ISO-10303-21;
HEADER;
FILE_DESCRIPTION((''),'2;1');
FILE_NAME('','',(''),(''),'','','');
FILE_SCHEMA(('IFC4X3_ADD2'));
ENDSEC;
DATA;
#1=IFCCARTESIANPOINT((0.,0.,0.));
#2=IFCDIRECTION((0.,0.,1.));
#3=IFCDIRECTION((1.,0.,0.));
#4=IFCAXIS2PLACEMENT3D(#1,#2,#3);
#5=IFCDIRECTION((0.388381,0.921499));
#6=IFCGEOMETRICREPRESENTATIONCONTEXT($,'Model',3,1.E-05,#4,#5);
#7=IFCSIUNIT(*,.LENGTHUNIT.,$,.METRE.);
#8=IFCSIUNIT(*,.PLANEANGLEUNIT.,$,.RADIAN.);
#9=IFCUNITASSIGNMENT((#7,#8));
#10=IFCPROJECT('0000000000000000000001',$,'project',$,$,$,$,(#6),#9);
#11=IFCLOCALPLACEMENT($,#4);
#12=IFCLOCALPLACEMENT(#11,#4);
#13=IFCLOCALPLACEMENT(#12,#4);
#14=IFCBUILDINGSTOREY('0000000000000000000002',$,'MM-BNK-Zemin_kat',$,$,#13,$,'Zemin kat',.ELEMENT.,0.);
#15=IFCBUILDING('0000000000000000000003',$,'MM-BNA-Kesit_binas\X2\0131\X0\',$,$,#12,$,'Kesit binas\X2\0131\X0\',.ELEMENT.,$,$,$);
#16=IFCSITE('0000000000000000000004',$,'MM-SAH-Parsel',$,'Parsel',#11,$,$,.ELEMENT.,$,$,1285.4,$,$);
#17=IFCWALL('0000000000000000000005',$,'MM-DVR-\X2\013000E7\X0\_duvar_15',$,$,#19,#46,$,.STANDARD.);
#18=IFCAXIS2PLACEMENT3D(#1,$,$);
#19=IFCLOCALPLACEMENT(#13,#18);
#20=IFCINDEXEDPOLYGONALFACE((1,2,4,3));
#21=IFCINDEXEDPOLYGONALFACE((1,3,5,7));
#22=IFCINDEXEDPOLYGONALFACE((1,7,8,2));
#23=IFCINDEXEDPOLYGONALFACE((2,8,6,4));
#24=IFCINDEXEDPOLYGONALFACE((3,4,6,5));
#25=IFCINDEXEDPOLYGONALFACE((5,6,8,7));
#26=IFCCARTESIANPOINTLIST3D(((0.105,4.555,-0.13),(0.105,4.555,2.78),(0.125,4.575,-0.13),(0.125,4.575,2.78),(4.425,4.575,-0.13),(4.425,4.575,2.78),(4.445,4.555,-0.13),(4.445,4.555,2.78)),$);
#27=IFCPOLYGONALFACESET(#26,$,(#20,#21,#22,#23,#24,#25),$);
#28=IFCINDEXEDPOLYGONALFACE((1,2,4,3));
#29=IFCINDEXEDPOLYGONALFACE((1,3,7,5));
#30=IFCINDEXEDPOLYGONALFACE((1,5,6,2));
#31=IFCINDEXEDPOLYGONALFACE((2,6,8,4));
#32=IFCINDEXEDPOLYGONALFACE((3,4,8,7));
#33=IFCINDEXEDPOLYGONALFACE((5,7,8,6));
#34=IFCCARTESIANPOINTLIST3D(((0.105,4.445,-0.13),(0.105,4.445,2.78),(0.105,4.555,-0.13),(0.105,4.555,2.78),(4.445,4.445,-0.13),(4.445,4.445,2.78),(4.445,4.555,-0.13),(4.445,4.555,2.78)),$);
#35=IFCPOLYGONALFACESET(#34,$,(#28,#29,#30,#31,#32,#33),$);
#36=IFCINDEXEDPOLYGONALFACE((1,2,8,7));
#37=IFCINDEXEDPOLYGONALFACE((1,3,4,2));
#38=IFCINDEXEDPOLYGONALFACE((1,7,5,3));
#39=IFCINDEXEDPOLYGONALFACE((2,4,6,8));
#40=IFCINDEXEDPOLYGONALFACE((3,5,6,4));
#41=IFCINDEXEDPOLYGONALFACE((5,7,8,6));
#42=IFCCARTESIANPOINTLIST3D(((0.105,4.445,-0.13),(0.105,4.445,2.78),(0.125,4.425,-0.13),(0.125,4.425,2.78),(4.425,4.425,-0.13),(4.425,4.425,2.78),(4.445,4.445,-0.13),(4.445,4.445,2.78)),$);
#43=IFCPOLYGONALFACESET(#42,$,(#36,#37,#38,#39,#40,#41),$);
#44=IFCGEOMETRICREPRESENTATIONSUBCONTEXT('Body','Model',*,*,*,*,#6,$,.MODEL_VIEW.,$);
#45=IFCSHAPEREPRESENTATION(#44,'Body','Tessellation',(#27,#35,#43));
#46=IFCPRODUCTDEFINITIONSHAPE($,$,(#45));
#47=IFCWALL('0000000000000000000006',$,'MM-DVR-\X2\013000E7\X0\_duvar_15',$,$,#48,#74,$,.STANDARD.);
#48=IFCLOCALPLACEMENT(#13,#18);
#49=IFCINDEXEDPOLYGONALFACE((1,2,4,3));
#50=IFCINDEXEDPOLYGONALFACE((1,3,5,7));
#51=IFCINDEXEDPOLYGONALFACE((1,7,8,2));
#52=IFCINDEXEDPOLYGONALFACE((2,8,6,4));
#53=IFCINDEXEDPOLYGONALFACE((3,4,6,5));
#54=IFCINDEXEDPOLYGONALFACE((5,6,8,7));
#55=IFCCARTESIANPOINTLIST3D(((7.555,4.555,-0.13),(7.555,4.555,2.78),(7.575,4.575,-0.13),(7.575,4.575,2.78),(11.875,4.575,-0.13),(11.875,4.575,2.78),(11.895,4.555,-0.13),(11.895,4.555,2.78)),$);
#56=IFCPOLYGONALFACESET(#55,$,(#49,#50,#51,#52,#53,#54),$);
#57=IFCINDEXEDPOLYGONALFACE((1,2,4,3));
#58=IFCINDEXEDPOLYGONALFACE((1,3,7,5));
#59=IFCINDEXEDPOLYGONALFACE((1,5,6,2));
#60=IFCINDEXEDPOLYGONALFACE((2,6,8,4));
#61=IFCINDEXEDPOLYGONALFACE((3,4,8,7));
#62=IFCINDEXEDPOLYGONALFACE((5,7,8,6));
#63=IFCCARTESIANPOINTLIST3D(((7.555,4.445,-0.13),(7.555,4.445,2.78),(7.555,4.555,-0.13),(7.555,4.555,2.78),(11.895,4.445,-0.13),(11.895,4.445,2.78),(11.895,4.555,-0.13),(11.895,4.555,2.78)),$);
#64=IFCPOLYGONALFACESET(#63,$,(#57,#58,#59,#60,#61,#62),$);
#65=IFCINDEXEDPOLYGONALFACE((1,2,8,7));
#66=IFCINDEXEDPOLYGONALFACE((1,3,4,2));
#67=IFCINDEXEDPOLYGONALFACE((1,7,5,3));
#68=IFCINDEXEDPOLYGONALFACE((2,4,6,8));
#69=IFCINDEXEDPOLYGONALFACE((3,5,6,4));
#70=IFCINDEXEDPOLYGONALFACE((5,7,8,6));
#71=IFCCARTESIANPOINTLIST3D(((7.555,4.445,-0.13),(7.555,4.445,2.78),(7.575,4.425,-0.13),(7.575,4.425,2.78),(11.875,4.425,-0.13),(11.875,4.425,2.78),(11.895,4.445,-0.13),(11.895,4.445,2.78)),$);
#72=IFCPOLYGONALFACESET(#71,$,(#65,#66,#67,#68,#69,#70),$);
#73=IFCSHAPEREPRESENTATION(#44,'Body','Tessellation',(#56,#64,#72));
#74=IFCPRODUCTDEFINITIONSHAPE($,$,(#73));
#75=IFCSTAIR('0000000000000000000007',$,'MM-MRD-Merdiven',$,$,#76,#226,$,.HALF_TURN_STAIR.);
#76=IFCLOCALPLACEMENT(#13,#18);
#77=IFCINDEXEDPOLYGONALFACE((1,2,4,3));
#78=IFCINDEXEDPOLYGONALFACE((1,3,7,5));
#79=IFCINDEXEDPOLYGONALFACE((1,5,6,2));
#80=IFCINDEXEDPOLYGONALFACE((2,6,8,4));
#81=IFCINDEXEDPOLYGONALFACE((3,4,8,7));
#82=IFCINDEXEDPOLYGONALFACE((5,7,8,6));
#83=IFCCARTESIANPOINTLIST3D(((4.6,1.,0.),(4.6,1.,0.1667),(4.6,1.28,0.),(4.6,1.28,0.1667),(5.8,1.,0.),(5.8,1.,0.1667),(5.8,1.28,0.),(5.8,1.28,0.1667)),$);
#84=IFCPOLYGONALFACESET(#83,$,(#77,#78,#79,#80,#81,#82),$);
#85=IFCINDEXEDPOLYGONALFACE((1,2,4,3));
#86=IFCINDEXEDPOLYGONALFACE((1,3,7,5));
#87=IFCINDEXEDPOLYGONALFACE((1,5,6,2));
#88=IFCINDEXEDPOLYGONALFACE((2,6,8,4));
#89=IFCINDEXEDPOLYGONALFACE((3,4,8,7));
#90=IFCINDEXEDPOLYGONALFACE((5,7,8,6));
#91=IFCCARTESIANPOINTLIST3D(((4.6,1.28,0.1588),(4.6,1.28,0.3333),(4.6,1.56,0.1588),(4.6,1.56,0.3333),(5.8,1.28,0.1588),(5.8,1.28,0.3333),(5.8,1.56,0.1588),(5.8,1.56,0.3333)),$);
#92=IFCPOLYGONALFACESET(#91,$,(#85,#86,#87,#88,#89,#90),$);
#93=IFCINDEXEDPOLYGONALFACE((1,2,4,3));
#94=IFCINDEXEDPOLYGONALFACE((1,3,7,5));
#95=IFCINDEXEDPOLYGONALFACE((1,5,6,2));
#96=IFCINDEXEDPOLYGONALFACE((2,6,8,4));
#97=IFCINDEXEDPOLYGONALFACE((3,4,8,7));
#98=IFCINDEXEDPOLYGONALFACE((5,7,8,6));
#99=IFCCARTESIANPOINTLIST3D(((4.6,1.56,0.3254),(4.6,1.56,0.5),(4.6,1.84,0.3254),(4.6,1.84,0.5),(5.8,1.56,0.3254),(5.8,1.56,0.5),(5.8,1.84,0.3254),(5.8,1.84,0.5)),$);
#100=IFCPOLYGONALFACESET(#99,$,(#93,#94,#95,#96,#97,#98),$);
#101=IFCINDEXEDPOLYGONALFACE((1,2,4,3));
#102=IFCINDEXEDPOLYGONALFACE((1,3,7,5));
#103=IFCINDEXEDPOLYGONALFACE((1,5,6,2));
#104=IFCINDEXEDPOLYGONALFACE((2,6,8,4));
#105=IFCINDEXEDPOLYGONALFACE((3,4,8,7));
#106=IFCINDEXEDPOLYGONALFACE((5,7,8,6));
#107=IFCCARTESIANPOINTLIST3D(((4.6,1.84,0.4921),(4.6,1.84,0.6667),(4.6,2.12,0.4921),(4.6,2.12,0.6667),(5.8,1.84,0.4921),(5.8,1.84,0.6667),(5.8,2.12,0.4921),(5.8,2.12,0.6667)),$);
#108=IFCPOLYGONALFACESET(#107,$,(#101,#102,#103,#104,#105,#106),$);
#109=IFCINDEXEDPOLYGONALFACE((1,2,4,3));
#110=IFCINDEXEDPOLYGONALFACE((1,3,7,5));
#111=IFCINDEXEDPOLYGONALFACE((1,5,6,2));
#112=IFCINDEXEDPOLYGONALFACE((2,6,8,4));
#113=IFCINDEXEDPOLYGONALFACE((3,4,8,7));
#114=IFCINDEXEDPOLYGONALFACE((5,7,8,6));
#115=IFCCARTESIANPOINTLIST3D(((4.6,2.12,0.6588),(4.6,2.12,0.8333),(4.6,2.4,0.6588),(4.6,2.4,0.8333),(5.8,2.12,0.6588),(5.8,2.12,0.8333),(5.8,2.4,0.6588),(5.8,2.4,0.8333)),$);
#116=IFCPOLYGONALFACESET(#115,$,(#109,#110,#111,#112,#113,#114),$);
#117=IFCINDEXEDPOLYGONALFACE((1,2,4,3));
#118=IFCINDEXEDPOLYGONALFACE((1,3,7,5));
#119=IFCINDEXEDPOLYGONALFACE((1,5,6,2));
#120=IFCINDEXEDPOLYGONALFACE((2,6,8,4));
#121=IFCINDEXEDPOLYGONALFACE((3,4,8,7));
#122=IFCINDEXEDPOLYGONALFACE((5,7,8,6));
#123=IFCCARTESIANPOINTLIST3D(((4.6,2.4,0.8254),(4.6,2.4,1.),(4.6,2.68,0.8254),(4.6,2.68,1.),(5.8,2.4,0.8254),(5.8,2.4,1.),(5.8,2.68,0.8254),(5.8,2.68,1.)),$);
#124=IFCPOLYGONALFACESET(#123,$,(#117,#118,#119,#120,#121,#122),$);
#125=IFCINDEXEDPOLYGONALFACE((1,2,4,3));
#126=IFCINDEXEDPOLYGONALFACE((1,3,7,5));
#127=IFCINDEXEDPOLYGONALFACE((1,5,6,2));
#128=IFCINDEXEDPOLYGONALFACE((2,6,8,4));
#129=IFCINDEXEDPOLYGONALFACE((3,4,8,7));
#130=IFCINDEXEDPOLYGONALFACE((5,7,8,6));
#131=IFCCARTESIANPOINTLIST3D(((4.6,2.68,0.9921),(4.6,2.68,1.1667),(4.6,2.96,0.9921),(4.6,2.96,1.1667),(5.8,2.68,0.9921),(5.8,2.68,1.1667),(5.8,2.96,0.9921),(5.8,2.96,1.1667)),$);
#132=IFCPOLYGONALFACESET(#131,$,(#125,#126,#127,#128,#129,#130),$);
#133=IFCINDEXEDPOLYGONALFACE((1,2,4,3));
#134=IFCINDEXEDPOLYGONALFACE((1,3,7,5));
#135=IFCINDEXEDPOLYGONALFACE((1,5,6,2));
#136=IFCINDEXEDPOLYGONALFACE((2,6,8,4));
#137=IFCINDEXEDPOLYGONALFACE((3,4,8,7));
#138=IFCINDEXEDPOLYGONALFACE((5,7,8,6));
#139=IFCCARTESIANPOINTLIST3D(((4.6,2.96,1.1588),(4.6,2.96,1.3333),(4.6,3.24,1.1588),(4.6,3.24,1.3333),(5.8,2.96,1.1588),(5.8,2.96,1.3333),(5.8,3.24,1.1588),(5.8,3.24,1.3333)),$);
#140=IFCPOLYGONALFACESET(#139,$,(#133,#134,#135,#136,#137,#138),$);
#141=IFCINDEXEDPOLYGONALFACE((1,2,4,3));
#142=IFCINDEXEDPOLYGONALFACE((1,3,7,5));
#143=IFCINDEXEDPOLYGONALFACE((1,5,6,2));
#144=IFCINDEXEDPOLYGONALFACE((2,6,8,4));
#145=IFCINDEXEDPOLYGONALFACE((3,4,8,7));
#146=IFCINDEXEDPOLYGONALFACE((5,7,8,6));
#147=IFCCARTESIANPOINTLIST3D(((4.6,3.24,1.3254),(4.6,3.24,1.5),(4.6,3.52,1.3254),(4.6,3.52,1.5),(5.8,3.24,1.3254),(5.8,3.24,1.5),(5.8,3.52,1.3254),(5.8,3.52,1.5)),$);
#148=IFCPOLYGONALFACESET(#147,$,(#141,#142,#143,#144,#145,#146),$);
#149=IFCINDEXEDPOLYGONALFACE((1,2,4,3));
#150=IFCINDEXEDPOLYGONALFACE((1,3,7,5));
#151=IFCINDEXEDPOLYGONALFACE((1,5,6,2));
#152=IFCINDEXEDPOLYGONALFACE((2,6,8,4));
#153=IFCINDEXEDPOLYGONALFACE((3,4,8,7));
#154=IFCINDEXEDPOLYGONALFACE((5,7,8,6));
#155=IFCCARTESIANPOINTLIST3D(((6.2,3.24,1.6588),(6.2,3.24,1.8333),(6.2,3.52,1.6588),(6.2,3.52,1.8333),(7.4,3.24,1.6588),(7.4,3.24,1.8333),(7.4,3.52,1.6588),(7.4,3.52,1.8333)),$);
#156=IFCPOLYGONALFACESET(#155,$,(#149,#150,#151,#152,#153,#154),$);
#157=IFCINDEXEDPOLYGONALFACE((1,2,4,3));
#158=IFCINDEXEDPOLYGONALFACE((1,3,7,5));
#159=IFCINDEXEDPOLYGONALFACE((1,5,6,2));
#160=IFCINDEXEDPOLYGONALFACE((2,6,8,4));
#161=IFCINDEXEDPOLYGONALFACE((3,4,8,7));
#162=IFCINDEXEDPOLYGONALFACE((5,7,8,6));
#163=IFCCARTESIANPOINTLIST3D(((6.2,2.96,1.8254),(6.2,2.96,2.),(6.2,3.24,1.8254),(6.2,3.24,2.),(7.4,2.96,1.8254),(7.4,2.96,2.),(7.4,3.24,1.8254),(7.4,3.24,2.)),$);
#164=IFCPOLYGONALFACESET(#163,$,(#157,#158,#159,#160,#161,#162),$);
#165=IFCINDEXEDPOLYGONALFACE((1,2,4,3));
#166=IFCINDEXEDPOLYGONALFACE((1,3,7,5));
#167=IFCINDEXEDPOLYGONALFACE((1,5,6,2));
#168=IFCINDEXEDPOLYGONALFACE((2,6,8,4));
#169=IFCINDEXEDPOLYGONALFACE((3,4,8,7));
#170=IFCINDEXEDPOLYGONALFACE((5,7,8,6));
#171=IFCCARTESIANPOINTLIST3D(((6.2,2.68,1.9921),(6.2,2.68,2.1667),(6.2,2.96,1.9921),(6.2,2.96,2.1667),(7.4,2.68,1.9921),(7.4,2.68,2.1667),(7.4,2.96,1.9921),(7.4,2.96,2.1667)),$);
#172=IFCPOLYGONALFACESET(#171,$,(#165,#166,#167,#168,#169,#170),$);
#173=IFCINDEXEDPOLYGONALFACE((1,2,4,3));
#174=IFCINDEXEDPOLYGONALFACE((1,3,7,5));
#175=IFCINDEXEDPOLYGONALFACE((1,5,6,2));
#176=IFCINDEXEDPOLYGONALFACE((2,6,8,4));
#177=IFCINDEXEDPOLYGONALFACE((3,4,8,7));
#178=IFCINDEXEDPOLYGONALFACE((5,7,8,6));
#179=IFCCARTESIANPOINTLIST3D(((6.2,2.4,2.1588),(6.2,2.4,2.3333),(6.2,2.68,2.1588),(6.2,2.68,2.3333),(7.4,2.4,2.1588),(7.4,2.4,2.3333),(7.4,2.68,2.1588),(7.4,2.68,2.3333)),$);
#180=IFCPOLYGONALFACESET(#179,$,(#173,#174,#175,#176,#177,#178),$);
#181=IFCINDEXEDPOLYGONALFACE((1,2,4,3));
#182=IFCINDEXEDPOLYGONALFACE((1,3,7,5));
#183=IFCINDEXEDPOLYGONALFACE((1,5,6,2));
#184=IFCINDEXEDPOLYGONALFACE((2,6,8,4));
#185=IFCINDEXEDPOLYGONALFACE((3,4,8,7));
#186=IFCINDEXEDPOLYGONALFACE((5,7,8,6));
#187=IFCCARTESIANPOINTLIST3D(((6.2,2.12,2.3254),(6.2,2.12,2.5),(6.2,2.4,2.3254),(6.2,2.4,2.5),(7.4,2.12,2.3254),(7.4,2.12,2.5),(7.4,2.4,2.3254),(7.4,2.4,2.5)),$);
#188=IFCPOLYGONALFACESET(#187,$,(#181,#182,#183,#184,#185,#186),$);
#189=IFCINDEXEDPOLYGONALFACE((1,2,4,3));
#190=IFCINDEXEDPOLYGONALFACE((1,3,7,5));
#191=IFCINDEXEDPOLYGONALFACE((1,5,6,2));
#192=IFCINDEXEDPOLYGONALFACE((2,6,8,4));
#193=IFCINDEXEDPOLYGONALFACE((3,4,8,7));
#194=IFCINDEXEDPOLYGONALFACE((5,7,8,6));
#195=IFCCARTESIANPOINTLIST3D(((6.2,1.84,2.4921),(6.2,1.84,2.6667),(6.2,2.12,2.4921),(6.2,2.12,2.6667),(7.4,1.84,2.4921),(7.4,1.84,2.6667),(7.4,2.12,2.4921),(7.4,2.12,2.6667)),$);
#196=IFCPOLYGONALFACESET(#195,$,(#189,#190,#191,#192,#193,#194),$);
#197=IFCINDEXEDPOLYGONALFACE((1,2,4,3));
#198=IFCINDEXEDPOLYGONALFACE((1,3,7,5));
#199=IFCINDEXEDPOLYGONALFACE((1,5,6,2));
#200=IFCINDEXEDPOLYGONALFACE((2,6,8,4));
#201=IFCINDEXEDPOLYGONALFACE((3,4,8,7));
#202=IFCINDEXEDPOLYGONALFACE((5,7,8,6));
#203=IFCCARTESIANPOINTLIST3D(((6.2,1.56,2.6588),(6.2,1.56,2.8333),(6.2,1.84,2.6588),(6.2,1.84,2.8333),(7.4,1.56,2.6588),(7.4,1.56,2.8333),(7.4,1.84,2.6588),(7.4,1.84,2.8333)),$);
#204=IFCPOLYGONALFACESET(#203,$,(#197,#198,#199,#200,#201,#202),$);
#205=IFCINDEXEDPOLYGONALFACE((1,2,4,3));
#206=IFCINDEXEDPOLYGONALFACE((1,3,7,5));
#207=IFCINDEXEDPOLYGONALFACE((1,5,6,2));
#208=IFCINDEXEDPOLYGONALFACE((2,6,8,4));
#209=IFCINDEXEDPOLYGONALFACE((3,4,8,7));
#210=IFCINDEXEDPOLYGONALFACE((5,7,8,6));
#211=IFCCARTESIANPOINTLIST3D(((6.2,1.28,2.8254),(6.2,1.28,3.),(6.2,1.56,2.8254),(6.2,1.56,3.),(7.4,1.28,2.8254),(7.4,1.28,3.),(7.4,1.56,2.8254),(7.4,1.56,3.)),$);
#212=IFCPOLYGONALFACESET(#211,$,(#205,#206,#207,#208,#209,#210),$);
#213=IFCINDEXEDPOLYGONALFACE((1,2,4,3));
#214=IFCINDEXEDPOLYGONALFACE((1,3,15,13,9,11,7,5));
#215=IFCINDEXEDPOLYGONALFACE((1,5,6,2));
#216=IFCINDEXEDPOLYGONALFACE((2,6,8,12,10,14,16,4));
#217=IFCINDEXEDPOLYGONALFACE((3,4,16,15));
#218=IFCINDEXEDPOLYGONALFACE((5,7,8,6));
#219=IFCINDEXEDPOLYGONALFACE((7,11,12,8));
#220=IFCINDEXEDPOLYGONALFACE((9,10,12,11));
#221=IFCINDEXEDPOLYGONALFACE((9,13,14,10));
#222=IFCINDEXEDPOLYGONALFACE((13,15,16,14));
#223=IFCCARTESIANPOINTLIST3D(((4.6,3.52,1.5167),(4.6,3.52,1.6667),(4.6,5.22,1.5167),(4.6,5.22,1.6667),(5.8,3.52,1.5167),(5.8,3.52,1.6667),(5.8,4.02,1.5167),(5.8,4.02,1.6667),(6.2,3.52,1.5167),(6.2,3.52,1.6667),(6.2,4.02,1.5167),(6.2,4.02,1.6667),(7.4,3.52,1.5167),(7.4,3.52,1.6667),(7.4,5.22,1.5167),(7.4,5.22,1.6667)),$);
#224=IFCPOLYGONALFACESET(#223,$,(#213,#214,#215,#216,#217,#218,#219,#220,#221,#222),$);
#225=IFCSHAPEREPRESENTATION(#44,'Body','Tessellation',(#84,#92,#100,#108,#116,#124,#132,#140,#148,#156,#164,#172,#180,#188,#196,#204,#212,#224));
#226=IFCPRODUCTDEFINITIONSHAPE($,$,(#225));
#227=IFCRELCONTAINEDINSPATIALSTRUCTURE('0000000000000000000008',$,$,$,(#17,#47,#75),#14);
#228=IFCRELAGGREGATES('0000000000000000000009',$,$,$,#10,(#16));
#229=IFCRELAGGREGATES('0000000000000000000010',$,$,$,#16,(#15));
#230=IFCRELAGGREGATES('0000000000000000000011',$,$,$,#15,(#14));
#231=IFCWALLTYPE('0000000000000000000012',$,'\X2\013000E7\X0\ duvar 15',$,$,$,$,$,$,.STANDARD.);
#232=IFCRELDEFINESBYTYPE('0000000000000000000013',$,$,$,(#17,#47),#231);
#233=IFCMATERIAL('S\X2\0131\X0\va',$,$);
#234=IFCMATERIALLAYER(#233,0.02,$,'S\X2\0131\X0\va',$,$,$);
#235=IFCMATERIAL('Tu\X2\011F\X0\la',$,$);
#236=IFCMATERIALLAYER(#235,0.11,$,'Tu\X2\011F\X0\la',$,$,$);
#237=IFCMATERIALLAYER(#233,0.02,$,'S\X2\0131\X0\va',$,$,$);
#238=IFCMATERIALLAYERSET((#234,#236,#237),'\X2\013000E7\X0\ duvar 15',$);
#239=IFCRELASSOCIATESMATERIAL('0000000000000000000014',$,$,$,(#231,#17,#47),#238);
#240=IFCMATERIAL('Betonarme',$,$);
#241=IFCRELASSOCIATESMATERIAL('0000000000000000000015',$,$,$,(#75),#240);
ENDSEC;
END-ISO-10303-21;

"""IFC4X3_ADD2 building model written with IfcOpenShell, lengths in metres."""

from ifc_helpers import new_model, si_unit, direction, frame, origin, origin_with_axes, place, context, subcontext, project, spatial, polyline, outline, extrude, material, layer, layer_set, type_object, element, save


model = new_model("IFC4X3_ADD2")

# Units and contexts
model_context = context("Model", 3, precision=1e-05, world=origin_with_axes(), true_north=direction((0.388381, 0.921499)))
body_context = subcontext(model_context, "Body", "Model", "MODEL_VIEW")
ifc_project = project(units=[si_unit("LENGTHUNIT", "METRE"), si_unit("PLANEANGLEUNIT", "RADIAN")], contexts=[model_context])

# Site, building, storey
site_placement = place(None, origin_with_axes())
site = spatial("IfcSite", under=ifc_project, at=site_placement, Name="MM-SAH-Parsel", ObjectType="Parsel", CompositionType="ELEMENT", RefElevation=1285.4)
building_placement = place(site_placement, origin_with_axes())
building = spatial("IfcBuilding", under=site, at=building_placement, Name="MM-BNA-Kesit_binası", LongName="Kesit binası", CompositionType="ELEMENT")
storey_placement = place(building_placement, origin_with_axes())
storey = spatial("IfcBuildingStorey", under=building, at=storey_placement, Name="MM-BNK-Zemin_kat", LongName="Zemin kat", CompositionType="ELEMENT", Elevation=0.0)

# Shared definitions
ifc_material_1 = material(Name="Betonarme")

# Shared definitions
ifc_material_2 = material(Name="Tuğla")

# Shared definitions
ifc_material_3 = material(Name="Sıva")
ifc_layer_1 = layer(ifc_material_3, 0.02, Name="Sıva")
ifc_layer_2 = layer(ifc_material_2, 0.11, Name="Tuğla")
ifc_layer_3 = layer(ifc_material_3, 0.02, Name="Sıva")
ifc_layer_set_1 = layer_set([ifc_layer_1, ifc_layer_2, ifc_layer_3], Name="İç duvar 15")
wall_type_1 = type_object("IfcWallType", Name="İç duvar 15", PredefinedType="STANDARD", material=ifc_layer_set_1)

# Walls
wall_1_placement = place(storey_placement, origin_with_axes())
element("IfcWall", 1, at=wall_1_placement, inside=storey, type_object=wall_type_1, material=ifc_layer_set_1, Name="MM-DVR-İç_duvar_15", PredefinedType="STANDARD", context=body_context, shape_type="SweptSolid", body=[
    extrude(outline(polyline([(0.125, 4.575), (4.425, 4.575), (4.445, 4.555), (0.105, 4.555), (0.125, 4.575)])), frame((0.0, 0.0, -0.13)), (0.0, 0.0, 1.0), 2.91),
    extrude(outline(polyline([(0.105, 4.555), (4.445, 4.555), (4.445, 4.445), (0.105, 4.445), (0.105, 4.555)])), frame((0.0, 0.0, -0.13)), (0.0, 0.0, 1.0), 2.91),
    extrude(outline(polyline([(0.105, 4.445), (4.445, 4.445), (4.425, 4.425), (0.125, 4.425), (0.105, 4.445)])), frame((0.0, 0.0, -0.13)), (0.0, 0.0, 1.0), 2.91),
])
wall_2_placement = place(storey_placement, origin_with_axes())
element("IfcWall", 2, at=wall_2_placement, inside=storey, type_object=wall_type_1, material=ifc_layer_set_1, Name="MM-DVR-İç_duvar_15", PredefinedType="STANDARD", context=body_context, shape_type="SweptSolid", body=[
    extrude(outline(polyline([(7.575, 4.575), (11.875, 4.575), (11.895, 4.555), (7.555, 4.555), (7.575, 4.575)])), frame((0.0, 0.0, -0.13)), (0.0, 0.0, 1.0), 2.91),
    extrude(outline(polyline([(7.555, 4.555), (11.895, 4.555), (11.895, 4.445), (7.555, 4.445), (7.555, 4.555)])), frame((0.0, 0.0, -0.13)), (0.0, 0.0, 1.0), 2.91),
    extrude(outline(polyline([(7.555, 4.445), (11.895, 4.445), (11.875, 4.425), (7.575, 4.425), (7.555, 4.445)])), frame((0.0, 0.0, -0.13)), (0.0, 0.0, 1.0), 2.91),
])

# Stair
stair_placement = place(storey_placement, origin_with_axes())
element("IfcStair", 3, at=stair_placement, inside=storey, material=ifc_material_1, Name="MM-MRD-Merdiven", PredefinedType="HALF_TURN_STAIR", context=body_context, shape_type="SweptSolid", body=[
    extrude(outline(polyline([(5.8, 1.0), (5.8, 1.28), (4.6, 1.28), (4.6, 1.0), (5.8, 1.0)])), origin(), (0.0, 0.0, 1.0), 0.1667),
    extrude(outline(polyline([(5.8, 1.28), (5.8, 1.56), (4.6, 1.56), (4.6, 1.28), (5.8, 1.28)])), frame((0.0, 0.0, 0.1588)), (0.0, 0.0, 1.0), 0.1746),
    extrude(outline(polyline([(5.8, 1.56), (5.8, 1.84), (4.6, 1.84), (4.6, 1.56), (5.8, 1.56)])), frame((0.0, 0.0, 0.3254)), (0.0, 0.0, 1.0), 0.1746),
    extrude(outline(polyline([(5.8, 1.84), (5.8, 2.12), (4.6, 2.12), (4.6, 1.84), (5.8, 1.84)])), frame((0.0, 0.0, 0.4921)), (0.0, 0.0, 1.0), 0.1746),
    extrude(outline(polyline([(5.8, 2.12), (5.8, 2.4), (4.6, 2.4), (4.6, 2.12), (5.8, 2.12)])), frame((0.0, 0.0, 0.6588)), (0.0, 0.0, 1.0), 0.1746),
    extrude(outline(polyline([(5.8, 2.4), (5.8, 2.68), (4.6, 2.68), (4.6, 2.4), (5.8, 2.4)])), frame((0.0, 0.0, 0.8254)), (0.0, 0.0, 1.0), 0.1746),
    extrude(outline(polyline([(5.8, 2.68), (5.8, 2.96), (4.6, 2.96), (4.6, 2.68), (5.8, 2.68)])), frame((0.0, 0.0, 0.9921)), (0.0, 0.0, 1.0), 0.1746),
    extrude(outline(polyline([(5.8, 2.96), (5.8, 3.24), (4.6, 3.24), (4.6, 2.96), (5.8, 2.96)])), frame((0.0, 0.0, 1.1588)), (0.0, 0.0, 1.0), 0.1746),
    extrude(outline(polyline([(5.8, 3.24), (5.8, 3.52), (4.6, 3.52), (4.6, 3.24), (5.8, 3.24)])), frame((0.0, 0.0, 1.3254)), (0.0, 0.0, 1.0), 0.1746),
    extrude(outline(polyline([(6.2, 3.52), (6.2, 3.24), (7.4, 3.24), (7.4, 3.52), (6.2, 3.52)])), frame((0.0, 0.0, 1.6588)), (0.0, 0.0, 1.0), 0.1746),
    extrude(outline(polyline([(6.2, 3.24), (6.2, 2.96), (7.4, 2.96), (7.4, 3.24), (6.2, 3.24)])), frame((0.0, 0.0, 1.8254)), (0.0, 0.0, 1.0), 0.1746),
    extrude(outline(polyline([(6.2, 2.96), (6.2, 2.68), (7.4, 2.68), (7.4, 2.96), (6.2, 2.96)])), frame((0.0, 0.0, 1.9921)), (0.0, 0.0, 1.0), 0.1746),
    extrude(outline(polyline([(6.2, 2.68), (6.2, 2.4), (7.4, 2.4), (7.4, 2.68), (6.2, 2.68)])), frame((0.0, 0.0, 2.1588)), (0.0, 0.0, 1.0), 0.1746),
    extrude(outline(polyline([(6.2, 2.4), (6.2, 2.12), (7.4, 2.12), (7.4, 2.4), (6.2, 2.4)])), frame((0.0, 0.0, 2.3254)), (0.0, 0.0, 1.0), 0.1746),
    extrude(outline(polyline([(6.2, 2.12), (6.2, 1.84), (7.4, 1.84), (7.4, 2.12), (6.2, 2.12)])), frame((0.0, 0.0, 2.4921)), (0.0, 0.0, 1.0), 0.1746),
    extrude(outline(polyline([(6.2, 1.84), (6.2, 1.56), (7.4, 1.56), (7.4, 1.84), (6.2, 1.84)])), frame((0.0, 0.0, 2.6588)), (0.0, 0.0, 1.0), 0.1746),
    extrude(outline(polyline([(6.2, 1.56), (6.2, 1.28), (7.4, 1.28), (7.4, 1.56), (6.2, 1.56)])), frame((0.0, 0.0, 2.8254)), (0.0, 0.0, 1.0), 0.1746),
    extrude(outline(polyline([(4.6, 3.52), (4.6, 5.22), (7.4, 5.22), (7.4, 3.52), (6.2, 3.52), (6.2, 4.02), (5.8, 4.02), (5.8, 3.52), (4.6, 3.52)])), frame((0.0, 0.0, 1.5167)), (0.0, 0.0, 1.0), 0.15),
])

save(model, "model.ifc")
